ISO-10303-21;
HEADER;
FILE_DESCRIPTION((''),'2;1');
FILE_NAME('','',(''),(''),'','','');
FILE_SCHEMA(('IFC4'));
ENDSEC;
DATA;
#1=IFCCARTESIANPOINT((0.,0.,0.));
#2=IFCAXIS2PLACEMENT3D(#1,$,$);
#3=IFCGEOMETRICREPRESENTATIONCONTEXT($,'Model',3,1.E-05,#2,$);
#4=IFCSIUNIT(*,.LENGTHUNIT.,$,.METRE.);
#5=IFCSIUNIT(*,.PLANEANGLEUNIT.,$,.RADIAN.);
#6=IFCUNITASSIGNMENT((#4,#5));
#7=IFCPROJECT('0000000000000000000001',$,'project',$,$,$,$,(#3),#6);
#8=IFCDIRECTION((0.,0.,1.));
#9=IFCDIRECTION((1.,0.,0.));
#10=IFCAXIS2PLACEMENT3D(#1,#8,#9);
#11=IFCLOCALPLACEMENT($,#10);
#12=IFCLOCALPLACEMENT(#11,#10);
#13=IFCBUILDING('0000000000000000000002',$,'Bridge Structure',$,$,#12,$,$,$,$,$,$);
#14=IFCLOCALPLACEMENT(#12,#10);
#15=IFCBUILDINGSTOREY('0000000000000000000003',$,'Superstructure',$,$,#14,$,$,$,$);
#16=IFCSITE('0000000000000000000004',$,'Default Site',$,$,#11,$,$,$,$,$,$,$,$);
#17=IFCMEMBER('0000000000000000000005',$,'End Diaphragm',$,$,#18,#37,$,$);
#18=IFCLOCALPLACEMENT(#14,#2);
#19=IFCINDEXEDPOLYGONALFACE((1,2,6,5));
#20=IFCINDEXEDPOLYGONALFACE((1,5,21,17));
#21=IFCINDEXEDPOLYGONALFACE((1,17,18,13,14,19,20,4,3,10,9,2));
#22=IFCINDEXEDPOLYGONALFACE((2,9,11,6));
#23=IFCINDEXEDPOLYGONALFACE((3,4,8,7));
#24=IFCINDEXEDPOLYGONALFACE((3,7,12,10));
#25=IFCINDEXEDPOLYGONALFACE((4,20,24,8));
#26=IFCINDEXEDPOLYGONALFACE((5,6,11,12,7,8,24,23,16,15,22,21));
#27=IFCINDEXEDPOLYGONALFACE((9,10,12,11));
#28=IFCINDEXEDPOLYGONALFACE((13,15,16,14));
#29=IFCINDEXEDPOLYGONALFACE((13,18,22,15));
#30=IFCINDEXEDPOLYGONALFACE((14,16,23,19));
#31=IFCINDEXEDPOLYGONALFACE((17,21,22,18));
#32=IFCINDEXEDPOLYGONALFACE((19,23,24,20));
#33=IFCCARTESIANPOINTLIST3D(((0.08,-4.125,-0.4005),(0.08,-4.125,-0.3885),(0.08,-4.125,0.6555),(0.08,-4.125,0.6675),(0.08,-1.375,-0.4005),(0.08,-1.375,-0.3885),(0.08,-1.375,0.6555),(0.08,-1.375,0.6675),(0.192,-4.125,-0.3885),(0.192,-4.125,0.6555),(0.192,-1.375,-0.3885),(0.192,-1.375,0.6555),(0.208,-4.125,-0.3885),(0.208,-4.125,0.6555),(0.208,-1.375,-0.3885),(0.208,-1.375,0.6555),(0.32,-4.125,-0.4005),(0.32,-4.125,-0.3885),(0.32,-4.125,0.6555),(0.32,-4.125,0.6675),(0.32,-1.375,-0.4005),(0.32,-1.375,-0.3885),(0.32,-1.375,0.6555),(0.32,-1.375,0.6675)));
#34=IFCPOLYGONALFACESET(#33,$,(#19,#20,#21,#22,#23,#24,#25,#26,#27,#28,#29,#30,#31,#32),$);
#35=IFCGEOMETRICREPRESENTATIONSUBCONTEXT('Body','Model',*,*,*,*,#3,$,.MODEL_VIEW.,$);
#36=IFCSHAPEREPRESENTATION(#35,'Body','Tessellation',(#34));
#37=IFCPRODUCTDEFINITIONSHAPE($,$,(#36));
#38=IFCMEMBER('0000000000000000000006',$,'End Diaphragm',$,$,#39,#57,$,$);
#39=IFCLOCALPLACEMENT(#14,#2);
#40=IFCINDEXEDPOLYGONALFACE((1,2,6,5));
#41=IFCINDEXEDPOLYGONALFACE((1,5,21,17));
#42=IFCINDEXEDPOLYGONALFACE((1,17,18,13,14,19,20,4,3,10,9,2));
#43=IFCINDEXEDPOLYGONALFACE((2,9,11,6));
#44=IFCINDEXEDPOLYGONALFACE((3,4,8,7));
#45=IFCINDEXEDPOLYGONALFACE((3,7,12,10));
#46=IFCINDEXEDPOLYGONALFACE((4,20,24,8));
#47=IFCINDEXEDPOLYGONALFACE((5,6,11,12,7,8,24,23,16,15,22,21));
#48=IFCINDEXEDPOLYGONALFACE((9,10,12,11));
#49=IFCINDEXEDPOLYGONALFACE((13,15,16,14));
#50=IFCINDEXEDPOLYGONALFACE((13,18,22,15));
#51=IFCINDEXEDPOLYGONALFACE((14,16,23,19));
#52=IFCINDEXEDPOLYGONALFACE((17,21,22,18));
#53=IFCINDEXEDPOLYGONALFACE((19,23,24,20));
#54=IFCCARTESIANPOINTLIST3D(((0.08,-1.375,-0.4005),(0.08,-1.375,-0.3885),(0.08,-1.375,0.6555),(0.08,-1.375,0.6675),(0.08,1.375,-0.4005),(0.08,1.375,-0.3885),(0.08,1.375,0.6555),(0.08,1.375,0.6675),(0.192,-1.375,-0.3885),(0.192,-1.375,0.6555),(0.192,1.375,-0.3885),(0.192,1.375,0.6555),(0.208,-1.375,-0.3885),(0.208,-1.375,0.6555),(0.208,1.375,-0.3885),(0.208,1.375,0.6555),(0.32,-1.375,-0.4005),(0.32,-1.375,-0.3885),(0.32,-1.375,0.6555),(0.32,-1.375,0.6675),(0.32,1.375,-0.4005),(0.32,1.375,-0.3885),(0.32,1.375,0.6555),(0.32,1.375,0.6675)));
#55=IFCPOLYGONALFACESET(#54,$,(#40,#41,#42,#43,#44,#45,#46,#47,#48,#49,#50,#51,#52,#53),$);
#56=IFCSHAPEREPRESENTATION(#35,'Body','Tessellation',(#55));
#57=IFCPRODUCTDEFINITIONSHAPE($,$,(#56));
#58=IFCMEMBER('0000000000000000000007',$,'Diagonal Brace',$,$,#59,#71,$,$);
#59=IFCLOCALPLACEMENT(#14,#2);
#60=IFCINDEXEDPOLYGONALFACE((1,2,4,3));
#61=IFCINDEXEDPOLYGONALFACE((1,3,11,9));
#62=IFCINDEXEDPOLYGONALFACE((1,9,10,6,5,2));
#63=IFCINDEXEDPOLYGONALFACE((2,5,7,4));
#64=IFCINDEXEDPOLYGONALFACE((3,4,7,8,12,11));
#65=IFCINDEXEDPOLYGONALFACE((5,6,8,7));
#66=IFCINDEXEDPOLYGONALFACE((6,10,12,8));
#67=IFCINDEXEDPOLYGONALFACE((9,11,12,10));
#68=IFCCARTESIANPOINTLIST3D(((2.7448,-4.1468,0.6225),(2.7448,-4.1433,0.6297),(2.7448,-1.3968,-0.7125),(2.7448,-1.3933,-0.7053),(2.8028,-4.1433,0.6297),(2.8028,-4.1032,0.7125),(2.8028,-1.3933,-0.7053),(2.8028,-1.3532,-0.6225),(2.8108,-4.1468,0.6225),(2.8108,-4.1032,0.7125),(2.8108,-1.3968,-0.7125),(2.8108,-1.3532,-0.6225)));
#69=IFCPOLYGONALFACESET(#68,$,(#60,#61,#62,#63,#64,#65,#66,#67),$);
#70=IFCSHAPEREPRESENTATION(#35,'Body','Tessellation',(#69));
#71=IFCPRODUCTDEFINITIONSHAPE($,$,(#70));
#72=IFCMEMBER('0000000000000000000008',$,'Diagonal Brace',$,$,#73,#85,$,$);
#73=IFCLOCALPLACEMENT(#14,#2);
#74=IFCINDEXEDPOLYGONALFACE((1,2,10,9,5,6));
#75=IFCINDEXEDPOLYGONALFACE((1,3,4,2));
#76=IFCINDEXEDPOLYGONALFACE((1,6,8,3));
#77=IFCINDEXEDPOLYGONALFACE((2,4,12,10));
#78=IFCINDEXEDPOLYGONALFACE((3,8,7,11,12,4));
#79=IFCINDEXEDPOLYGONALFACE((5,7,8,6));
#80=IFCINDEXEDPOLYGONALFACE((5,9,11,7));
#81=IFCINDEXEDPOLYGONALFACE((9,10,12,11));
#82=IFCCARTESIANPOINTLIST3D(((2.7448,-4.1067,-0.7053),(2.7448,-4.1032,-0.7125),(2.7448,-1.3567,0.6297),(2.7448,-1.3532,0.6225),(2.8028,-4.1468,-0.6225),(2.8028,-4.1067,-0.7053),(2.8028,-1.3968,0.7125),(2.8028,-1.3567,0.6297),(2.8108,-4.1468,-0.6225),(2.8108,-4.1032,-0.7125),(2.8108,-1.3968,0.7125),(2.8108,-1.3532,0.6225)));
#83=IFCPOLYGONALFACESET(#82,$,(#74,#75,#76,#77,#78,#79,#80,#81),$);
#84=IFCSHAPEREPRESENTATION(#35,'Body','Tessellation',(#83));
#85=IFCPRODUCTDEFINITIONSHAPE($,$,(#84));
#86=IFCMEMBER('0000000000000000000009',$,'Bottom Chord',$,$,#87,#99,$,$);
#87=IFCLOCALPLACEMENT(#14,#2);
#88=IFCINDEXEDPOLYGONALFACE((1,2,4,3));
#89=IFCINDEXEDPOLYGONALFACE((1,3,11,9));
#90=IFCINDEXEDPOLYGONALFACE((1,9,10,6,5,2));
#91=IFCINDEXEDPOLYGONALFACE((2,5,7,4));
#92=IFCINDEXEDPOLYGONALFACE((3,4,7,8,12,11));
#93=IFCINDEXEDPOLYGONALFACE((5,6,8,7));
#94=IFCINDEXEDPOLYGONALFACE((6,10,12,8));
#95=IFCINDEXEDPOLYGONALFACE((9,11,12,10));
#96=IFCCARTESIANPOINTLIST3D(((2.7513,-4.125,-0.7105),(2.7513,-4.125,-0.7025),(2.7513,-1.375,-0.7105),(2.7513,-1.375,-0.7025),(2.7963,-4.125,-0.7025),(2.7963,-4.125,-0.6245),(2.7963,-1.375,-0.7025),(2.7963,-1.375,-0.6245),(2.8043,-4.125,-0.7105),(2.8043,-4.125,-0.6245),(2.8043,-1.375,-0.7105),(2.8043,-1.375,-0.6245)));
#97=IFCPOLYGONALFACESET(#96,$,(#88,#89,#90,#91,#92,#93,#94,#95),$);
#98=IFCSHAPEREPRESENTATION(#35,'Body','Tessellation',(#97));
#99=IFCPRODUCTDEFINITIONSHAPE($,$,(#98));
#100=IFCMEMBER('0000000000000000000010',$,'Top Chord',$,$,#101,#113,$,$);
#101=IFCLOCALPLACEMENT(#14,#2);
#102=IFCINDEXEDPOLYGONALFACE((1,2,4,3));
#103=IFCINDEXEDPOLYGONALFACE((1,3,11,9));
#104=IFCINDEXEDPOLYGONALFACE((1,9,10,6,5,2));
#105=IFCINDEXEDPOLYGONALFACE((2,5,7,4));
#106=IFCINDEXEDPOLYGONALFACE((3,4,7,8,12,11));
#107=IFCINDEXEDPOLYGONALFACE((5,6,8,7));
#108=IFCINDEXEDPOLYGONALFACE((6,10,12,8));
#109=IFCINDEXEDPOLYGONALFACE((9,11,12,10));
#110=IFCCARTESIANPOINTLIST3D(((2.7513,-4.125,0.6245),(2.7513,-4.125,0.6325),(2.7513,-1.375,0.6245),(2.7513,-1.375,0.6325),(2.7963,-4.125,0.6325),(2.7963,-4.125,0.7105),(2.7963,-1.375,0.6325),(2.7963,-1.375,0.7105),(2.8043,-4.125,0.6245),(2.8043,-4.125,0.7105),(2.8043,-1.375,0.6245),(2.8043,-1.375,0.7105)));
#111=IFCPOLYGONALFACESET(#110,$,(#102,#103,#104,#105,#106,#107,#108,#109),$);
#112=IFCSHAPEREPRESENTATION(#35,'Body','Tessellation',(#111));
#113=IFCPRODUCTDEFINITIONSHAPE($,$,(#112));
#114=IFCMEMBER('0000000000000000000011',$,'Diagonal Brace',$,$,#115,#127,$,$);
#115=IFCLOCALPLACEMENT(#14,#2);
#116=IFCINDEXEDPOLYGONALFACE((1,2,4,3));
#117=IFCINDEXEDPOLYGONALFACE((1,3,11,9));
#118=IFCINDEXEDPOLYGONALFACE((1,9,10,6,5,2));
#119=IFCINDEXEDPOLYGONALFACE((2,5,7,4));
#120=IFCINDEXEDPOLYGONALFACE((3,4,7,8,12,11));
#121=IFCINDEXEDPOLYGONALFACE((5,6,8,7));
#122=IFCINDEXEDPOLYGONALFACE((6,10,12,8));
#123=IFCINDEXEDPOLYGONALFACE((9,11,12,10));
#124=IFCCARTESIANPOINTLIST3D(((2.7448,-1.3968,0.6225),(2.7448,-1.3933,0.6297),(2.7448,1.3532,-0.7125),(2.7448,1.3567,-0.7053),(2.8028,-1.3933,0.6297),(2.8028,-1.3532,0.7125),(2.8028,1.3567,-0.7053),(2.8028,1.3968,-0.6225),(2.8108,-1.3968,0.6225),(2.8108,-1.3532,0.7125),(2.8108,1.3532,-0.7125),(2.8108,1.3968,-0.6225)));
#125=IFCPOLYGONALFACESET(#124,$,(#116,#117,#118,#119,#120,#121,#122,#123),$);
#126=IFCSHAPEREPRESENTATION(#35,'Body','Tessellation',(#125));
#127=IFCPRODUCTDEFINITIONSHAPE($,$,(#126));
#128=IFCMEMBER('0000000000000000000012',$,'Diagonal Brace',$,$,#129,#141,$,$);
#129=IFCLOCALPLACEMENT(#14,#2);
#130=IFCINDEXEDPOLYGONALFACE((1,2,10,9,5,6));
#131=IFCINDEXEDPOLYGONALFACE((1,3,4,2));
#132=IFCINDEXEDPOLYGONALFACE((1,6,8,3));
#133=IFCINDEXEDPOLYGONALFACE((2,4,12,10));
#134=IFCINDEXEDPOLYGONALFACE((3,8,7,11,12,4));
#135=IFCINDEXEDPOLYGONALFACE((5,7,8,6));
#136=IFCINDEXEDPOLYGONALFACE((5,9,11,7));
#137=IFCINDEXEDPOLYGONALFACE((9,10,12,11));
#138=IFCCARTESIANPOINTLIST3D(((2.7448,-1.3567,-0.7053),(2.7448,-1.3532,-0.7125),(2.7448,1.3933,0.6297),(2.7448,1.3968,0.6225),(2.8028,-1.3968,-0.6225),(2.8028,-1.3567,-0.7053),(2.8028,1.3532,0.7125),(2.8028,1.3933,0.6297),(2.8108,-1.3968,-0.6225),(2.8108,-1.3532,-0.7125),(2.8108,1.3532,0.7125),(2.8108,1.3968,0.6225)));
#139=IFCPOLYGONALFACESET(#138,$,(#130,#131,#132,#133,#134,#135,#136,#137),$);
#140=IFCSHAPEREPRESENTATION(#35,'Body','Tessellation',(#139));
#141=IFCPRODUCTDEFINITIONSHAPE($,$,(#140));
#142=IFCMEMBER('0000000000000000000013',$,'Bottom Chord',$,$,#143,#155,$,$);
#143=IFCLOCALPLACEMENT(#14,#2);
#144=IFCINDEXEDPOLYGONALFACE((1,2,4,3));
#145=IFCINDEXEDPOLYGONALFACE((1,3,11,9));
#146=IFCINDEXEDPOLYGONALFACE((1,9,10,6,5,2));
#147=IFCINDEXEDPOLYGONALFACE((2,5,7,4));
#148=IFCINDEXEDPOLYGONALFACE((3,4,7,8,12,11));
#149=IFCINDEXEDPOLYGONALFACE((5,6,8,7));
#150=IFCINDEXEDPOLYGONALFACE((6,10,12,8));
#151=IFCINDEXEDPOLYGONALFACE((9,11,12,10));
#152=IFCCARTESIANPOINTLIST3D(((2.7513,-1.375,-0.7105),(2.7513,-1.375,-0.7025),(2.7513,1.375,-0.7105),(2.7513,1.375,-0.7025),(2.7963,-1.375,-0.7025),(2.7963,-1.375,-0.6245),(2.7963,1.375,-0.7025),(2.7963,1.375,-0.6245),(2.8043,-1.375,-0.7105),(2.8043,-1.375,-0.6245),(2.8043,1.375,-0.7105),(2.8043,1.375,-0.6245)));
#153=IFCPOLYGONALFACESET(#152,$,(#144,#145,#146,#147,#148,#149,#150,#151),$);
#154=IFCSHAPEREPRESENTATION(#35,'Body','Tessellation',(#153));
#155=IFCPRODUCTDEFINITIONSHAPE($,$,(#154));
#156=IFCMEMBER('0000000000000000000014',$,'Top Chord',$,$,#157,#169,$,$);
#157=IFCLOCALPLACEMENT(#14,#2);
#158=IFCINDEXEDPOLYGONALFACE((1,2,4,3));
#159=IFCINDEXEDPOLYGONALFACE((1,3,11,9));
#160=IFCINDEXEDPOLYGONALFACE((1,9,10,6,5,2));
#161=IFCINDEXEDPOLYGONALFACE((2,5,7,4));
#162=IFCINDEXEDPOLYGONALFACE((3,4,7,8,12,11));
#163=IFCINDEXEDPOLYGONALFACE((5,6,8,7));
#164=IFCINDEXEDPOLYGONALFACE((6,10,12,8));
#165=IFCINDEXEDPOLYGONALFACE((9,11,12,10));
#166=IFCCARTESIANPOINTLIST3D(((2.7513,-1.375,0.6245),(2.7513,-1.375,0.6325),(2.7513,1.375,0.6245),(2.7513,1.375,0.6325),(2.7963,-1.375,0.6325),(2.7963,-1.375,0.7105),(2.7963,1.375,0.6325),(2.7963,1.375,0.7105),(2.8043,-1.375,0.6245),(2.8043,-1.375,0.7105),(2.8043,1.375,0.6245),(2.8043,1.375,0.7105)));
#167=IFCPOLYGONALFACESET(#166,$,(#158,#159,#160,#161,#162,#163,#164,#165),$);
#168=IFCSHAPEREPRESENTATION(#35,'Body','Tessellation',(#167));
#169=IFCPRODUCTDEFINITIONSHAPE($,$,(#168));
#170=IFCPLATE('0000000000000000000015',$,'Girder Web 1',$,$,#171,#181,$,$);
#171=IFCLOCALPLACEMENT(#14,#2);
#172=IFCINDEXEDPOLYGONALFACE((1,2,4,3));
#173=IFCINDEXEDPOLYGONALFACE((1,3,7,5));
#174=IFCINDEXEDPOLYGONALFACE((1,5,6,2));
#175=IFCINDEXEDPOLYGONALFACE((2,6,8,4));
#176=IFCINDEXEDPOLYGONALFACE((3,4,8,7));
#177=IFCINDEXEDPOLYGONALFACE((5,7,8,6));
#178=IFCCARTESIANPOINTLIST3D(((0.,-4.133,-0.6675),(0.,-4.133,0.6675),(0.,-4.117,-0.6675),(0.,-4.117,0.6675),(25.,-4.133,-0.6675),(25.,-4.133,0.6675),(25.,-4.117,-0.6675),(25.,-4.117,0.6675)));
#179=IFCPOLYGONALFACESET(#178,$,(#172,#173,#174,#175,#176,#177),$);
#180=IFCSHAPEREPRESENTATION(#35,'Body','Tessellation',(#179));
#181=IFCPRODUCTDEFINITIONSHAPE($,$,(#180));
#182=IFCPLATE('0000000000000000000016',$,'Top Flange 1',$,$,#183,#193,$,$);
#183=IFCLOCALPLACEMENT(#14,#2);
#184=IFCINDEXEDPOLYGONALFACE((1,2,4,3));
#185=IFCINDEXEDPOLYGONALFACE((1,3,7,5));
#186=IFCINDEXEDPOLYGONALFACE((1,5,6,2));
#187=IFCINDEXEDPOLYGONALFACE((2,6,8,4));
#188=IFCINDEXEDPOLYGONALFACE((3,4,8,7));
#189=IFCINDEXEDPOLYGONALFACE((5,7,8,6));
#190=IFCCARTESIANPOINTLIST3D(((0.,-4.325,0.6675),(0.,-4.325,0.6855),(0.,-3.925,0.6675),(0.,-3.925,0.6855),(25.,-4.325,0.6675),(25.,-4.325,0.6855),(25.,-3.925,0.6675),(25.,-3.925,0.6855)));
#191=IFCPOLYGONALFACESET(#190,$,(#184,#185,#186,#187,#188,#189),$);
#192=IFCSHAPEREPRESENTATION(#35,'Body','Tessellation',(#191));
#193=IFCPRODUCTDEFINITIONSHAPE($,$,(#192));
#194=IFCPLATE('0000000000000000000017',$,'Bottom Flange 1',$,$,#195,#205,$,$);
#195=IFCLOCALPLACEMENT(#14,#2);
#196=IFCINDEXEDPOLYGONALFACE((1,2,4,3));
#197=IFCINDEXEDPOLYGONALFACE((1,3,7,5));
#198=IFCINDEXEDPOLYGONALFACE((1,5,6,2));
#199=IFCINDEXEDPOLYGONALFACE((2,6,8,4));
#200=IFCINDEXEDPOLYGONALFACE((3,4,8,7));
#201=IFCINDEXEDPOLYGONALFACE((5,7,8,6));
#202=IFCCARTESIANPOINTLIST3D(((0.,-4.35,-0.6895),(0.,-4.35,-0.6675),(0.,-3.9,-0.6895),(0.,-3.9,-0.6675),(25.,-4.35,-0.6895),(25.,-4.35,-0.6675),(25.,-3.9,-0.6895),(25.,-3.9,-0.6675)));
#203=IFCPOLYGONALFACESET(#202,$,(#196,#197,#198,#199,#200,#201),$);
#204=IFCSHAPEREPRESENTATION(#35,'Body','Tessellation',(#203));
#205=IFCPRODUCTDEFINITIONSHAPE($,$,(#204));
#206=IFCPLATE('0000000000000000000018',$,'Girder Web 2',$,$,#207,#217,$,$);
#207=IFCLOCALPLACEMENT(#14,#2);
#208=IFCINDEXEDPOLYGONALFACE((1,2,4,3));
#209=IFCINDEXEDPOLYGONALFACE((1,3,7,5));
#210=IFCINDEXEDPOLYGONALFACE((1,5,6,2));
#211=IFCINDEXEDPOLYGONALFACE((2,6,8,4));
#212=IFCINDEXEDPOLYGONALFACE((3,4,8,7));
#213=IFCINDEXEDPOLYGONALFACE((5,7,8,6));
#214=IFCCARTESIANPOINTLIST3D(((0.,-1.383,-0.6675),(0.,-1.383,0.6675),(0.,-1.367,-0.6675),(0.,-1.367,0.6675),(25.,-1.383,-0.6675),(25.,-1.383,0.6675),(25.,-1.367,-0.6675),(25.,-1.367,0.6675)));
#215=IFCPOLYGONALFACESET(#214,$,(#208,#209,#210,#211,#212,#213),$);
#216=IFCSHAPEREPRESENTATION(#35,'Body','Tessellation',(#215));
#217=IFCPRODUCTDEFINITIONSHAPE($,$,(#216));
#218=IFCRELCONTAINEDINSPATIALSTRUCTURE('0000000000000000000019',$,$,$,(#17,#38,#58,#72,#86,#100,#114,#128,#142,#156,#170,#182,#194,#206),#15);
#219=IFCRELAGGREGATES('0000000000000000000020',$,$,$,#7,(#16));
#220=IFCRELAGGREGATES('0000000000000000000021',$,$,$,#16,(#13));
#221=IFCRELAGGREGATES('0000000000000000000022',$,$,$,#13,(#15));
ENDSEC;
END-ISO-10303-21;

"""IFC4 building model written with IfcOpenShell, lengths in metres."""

from ifc_helpers import new_model, si_unit, frame, origin, origin_with_axes, origin_2d_with_axis, place, context, subcontext, project, spatial, rectangle, i_section, l_section, extrude, element, save


model = new_model("IFC4")

# Units and contexts
model_context = context("Model", 3, precision=1e-05, world=origin())
body_context = subcontext(model_context, "Body", "Model", "MODEL_VIEW")
ifc_project = project(units=[si_unit("LENGTHUNIT", "METRE"), si_unit("PLANEANGLEUNIT", "RADIAN")], contexts=[model_context])

# Site, building, storey
site_placement = place(None, origin_with_axes())
site = spatial("IfcSite", under=ifc_project, at=site_placement, Name="Default Site")
building_placement = place(site_placement, origin_with_axes())
building = spatial("IfcBuilding", under=site, at=building_placement, Name="Bridge Structure")
storey_placement = place(building_placement, origin_with_axes())
storey = spatial("IfcBuildingStorey", under=building, at=storey_placement, Name="Superstructure")

# Members
for number, where, z_axis, x_axis, name in (
    (1, (0.2, -4.125, 0.1335), (0.0, 1.0, 0.0), (-1.0, 0.0, 0.0), "End Diaphragm"),
    (2, (0.2, -1.375, 0.1335), (0.0, 1.0, 0.0), (-1.0, 0.0, 0.0), "End Diaphragm"),
):
    element("IfcMember", number, at=place(storey_placement, frame(where, z_axis=z_axis, x_axis=x_axis)), inside=storey, Name=name, context=body_context, shape_type="SweptSolid", body=[
        extrude(i_section(OverallWidth=0.24, OverallDepth=1.068, WebThickness=0.016, FlangeThickness=0.012, at=origin_2d_with_axis()), origin_with_axes(), (0.0, 0.0, 1.0), 2.75),
    ])
for number, where, z_axis, x_axis, name in (
    (3, (2.7778, -4.125, 0.6675), (0.0, 0.8996, -0.436715), (-1.0, 0.0, 0.0), "Diagonal Brace"),
    (4, (2.7778, -4.125, -0.6675), (0.0, 0.8996, 0.436715), (-1.0, 0.0, 0.0), "Diagonal Brace"),
):
    element("IfcMember", number, at=place(storey_placement, frame(where, z_axis=z_axis, x_axis=x_axis)), inside=storey, Name=name, context=body_context, shape_type="SweptSolid", body=[
        extrude(l_section(Depth=0.1, Width=0.066, Thickness=0.008, at=origin_2d_with_axis()), origin_with_axes(), (0.0, 0.0, 1.0), 3.0569),
    ])
for number, where, z_axis, x_axis, name in (
    (5, (2.7778, -4.125, -0.6675), (0.0, 1.0, 0.0), (-1.0, 0.0, 0.0), "Bottom Chord"),
    (6, (2.7778, -4.125, 0.6675), (0.0, 1.0, 0.0), (-1.0, 0.0, 0.0), "Top Chord"),
):
    element("IfcMember", number, at=place(storey_placement, frame(where, z_axis=z_axis, x_axis=x_axis)), inside=storey, Name=name, context=body_context, shape_type="SweptSolid", body=[
        extrude(l_section(Depth=0.086, Width=0.053, Thickness=0.008, at=origin_2d_with_axis()), origin_with_axes(), (0.0, 0.0, 1.0), 2.75),
    ])
for number, where, z_axis, x_axis, name in (
    (7, (2.7778, -1.375, 0.6675), (0.0, 0.8996, -0.436715), (-1.0, 0.0, 0.0), "Diagonal Brace"),
    (8, (2.7778, -1.375, -0.6675), (0.0, 0.8996, 0.436715), (-1.0, 0.0, 0.0), "Diagonal Brace"),
):
    element("IfcMember", number, at=place(storey_placement, frame(where, z_axis=z_axis, x_axis=x_axis)), inside=storey, Name=name, context=body_context, shape_type="SweptSolid", body=[
        extrude(l_section(Depth=0.1, Width=0.066, Thickness=0.008, at=origin_2d_with_axis()), origin_with_axes(), (0.0, 0.0, 1.0), 3.0569),
    ])
for number, where, z_axis, x_axis, name in (
    (9, (2.7778, -1.375, -0.6675), (0.0, 1.0, 0.0), (-1.0, 0.0, 0.0), "Bottom Chord"),
    (10, (2.7778, -1.375, 0.6675), (0.0, 1.0, 0.0), (-1.0, 0.0, 0.0), "Top Chord"),
):
    element("IfcMember", number, at=place(storey_placement, frame(where, z_axis=z_axis, x_axis=x_axis)), inside=storey, Name=name, context=body_context, shape_type="SweptSolid", body=[
        extrude(l_section(Depth=0.086, Width=0.053, Thickness=0.008, at=origin_2d_with_axis()), origin_with_axes(), (0.0, 0.0, 1.0), 2.75),
    ])

# Plates
plate_1_placement = place(storey_placement, frame((0.0, -4.125, 0.0), z_axis=(1.0, 0.0, 0.0), x_axis=(0.0, 1.0, 0.0)))
element("IfcPlate", 11, at=plate_1_placement, inside=storey, Name="Girder Web 1", context=body_context, shape_type="SweptSolid", body=[
    extrude(rectangle(XDim=0.016, YDim=1.335, at=origin_2d_with_axis()), origin_with_axes(), (0.0, 0.0, 1.0), 25.0),
])
plate_2_placement = place(storey_placement, frame((0.0, -4.125, 0.6765), z_axis=(1.0, 0.0, 0.0), x_axis=(0.0, 1.0, 0.0)))
element("IfcPlate", 12, at=plate_2_placement, inside=storey, Name="Top Flange 1", context=body_context, shape_type="SweptSolid", body=[
    extrude(rectangle(XDim=0.4, YDim=0.018, at=origin_2d_with_axis()), origin_with_axes(), (0.0, 0.0, 1.0), 25.0),
])
plate_3_placement = place(storey_placement, frame((0.0, -4.125, -0.6785), z_axis=(1.0, 0.0, 0.0), x_axis=(0.0, 1.0, 0.0)))
element("IfcPlate", 13, at=plate_3_placement, inside=storey, Name="Bottom Flange 1", context=body_context, shape_type="SweptSolid", body=[
    extrude(rectangle(XDim=0.45, YDim=0.022, at=origin_2d_with_axis()), origin_with_axes(), (0.0, 0.0, 1.0), 25.0),
])
plate_4_placement = place(storey_placement, frame((0.0, -1.375, 0.0), z_axis=(1.0, 0.0, 0.0), x_axis=(0.0, 1.0, 0.0)))
element("IfcPlate", 14, at=plate_4_placement, inside=storey, Name="Girder Web 2", context=body_context, shape_type="SweptSolid", body=[
    extrude(rectangle(XDim=0.016, YDim=1.335, at=origin_2d_with_axis()), origin_with_axes(), (0.0, 0.0, 1.0), 25.0),
])

save(model, "model.ifc")
